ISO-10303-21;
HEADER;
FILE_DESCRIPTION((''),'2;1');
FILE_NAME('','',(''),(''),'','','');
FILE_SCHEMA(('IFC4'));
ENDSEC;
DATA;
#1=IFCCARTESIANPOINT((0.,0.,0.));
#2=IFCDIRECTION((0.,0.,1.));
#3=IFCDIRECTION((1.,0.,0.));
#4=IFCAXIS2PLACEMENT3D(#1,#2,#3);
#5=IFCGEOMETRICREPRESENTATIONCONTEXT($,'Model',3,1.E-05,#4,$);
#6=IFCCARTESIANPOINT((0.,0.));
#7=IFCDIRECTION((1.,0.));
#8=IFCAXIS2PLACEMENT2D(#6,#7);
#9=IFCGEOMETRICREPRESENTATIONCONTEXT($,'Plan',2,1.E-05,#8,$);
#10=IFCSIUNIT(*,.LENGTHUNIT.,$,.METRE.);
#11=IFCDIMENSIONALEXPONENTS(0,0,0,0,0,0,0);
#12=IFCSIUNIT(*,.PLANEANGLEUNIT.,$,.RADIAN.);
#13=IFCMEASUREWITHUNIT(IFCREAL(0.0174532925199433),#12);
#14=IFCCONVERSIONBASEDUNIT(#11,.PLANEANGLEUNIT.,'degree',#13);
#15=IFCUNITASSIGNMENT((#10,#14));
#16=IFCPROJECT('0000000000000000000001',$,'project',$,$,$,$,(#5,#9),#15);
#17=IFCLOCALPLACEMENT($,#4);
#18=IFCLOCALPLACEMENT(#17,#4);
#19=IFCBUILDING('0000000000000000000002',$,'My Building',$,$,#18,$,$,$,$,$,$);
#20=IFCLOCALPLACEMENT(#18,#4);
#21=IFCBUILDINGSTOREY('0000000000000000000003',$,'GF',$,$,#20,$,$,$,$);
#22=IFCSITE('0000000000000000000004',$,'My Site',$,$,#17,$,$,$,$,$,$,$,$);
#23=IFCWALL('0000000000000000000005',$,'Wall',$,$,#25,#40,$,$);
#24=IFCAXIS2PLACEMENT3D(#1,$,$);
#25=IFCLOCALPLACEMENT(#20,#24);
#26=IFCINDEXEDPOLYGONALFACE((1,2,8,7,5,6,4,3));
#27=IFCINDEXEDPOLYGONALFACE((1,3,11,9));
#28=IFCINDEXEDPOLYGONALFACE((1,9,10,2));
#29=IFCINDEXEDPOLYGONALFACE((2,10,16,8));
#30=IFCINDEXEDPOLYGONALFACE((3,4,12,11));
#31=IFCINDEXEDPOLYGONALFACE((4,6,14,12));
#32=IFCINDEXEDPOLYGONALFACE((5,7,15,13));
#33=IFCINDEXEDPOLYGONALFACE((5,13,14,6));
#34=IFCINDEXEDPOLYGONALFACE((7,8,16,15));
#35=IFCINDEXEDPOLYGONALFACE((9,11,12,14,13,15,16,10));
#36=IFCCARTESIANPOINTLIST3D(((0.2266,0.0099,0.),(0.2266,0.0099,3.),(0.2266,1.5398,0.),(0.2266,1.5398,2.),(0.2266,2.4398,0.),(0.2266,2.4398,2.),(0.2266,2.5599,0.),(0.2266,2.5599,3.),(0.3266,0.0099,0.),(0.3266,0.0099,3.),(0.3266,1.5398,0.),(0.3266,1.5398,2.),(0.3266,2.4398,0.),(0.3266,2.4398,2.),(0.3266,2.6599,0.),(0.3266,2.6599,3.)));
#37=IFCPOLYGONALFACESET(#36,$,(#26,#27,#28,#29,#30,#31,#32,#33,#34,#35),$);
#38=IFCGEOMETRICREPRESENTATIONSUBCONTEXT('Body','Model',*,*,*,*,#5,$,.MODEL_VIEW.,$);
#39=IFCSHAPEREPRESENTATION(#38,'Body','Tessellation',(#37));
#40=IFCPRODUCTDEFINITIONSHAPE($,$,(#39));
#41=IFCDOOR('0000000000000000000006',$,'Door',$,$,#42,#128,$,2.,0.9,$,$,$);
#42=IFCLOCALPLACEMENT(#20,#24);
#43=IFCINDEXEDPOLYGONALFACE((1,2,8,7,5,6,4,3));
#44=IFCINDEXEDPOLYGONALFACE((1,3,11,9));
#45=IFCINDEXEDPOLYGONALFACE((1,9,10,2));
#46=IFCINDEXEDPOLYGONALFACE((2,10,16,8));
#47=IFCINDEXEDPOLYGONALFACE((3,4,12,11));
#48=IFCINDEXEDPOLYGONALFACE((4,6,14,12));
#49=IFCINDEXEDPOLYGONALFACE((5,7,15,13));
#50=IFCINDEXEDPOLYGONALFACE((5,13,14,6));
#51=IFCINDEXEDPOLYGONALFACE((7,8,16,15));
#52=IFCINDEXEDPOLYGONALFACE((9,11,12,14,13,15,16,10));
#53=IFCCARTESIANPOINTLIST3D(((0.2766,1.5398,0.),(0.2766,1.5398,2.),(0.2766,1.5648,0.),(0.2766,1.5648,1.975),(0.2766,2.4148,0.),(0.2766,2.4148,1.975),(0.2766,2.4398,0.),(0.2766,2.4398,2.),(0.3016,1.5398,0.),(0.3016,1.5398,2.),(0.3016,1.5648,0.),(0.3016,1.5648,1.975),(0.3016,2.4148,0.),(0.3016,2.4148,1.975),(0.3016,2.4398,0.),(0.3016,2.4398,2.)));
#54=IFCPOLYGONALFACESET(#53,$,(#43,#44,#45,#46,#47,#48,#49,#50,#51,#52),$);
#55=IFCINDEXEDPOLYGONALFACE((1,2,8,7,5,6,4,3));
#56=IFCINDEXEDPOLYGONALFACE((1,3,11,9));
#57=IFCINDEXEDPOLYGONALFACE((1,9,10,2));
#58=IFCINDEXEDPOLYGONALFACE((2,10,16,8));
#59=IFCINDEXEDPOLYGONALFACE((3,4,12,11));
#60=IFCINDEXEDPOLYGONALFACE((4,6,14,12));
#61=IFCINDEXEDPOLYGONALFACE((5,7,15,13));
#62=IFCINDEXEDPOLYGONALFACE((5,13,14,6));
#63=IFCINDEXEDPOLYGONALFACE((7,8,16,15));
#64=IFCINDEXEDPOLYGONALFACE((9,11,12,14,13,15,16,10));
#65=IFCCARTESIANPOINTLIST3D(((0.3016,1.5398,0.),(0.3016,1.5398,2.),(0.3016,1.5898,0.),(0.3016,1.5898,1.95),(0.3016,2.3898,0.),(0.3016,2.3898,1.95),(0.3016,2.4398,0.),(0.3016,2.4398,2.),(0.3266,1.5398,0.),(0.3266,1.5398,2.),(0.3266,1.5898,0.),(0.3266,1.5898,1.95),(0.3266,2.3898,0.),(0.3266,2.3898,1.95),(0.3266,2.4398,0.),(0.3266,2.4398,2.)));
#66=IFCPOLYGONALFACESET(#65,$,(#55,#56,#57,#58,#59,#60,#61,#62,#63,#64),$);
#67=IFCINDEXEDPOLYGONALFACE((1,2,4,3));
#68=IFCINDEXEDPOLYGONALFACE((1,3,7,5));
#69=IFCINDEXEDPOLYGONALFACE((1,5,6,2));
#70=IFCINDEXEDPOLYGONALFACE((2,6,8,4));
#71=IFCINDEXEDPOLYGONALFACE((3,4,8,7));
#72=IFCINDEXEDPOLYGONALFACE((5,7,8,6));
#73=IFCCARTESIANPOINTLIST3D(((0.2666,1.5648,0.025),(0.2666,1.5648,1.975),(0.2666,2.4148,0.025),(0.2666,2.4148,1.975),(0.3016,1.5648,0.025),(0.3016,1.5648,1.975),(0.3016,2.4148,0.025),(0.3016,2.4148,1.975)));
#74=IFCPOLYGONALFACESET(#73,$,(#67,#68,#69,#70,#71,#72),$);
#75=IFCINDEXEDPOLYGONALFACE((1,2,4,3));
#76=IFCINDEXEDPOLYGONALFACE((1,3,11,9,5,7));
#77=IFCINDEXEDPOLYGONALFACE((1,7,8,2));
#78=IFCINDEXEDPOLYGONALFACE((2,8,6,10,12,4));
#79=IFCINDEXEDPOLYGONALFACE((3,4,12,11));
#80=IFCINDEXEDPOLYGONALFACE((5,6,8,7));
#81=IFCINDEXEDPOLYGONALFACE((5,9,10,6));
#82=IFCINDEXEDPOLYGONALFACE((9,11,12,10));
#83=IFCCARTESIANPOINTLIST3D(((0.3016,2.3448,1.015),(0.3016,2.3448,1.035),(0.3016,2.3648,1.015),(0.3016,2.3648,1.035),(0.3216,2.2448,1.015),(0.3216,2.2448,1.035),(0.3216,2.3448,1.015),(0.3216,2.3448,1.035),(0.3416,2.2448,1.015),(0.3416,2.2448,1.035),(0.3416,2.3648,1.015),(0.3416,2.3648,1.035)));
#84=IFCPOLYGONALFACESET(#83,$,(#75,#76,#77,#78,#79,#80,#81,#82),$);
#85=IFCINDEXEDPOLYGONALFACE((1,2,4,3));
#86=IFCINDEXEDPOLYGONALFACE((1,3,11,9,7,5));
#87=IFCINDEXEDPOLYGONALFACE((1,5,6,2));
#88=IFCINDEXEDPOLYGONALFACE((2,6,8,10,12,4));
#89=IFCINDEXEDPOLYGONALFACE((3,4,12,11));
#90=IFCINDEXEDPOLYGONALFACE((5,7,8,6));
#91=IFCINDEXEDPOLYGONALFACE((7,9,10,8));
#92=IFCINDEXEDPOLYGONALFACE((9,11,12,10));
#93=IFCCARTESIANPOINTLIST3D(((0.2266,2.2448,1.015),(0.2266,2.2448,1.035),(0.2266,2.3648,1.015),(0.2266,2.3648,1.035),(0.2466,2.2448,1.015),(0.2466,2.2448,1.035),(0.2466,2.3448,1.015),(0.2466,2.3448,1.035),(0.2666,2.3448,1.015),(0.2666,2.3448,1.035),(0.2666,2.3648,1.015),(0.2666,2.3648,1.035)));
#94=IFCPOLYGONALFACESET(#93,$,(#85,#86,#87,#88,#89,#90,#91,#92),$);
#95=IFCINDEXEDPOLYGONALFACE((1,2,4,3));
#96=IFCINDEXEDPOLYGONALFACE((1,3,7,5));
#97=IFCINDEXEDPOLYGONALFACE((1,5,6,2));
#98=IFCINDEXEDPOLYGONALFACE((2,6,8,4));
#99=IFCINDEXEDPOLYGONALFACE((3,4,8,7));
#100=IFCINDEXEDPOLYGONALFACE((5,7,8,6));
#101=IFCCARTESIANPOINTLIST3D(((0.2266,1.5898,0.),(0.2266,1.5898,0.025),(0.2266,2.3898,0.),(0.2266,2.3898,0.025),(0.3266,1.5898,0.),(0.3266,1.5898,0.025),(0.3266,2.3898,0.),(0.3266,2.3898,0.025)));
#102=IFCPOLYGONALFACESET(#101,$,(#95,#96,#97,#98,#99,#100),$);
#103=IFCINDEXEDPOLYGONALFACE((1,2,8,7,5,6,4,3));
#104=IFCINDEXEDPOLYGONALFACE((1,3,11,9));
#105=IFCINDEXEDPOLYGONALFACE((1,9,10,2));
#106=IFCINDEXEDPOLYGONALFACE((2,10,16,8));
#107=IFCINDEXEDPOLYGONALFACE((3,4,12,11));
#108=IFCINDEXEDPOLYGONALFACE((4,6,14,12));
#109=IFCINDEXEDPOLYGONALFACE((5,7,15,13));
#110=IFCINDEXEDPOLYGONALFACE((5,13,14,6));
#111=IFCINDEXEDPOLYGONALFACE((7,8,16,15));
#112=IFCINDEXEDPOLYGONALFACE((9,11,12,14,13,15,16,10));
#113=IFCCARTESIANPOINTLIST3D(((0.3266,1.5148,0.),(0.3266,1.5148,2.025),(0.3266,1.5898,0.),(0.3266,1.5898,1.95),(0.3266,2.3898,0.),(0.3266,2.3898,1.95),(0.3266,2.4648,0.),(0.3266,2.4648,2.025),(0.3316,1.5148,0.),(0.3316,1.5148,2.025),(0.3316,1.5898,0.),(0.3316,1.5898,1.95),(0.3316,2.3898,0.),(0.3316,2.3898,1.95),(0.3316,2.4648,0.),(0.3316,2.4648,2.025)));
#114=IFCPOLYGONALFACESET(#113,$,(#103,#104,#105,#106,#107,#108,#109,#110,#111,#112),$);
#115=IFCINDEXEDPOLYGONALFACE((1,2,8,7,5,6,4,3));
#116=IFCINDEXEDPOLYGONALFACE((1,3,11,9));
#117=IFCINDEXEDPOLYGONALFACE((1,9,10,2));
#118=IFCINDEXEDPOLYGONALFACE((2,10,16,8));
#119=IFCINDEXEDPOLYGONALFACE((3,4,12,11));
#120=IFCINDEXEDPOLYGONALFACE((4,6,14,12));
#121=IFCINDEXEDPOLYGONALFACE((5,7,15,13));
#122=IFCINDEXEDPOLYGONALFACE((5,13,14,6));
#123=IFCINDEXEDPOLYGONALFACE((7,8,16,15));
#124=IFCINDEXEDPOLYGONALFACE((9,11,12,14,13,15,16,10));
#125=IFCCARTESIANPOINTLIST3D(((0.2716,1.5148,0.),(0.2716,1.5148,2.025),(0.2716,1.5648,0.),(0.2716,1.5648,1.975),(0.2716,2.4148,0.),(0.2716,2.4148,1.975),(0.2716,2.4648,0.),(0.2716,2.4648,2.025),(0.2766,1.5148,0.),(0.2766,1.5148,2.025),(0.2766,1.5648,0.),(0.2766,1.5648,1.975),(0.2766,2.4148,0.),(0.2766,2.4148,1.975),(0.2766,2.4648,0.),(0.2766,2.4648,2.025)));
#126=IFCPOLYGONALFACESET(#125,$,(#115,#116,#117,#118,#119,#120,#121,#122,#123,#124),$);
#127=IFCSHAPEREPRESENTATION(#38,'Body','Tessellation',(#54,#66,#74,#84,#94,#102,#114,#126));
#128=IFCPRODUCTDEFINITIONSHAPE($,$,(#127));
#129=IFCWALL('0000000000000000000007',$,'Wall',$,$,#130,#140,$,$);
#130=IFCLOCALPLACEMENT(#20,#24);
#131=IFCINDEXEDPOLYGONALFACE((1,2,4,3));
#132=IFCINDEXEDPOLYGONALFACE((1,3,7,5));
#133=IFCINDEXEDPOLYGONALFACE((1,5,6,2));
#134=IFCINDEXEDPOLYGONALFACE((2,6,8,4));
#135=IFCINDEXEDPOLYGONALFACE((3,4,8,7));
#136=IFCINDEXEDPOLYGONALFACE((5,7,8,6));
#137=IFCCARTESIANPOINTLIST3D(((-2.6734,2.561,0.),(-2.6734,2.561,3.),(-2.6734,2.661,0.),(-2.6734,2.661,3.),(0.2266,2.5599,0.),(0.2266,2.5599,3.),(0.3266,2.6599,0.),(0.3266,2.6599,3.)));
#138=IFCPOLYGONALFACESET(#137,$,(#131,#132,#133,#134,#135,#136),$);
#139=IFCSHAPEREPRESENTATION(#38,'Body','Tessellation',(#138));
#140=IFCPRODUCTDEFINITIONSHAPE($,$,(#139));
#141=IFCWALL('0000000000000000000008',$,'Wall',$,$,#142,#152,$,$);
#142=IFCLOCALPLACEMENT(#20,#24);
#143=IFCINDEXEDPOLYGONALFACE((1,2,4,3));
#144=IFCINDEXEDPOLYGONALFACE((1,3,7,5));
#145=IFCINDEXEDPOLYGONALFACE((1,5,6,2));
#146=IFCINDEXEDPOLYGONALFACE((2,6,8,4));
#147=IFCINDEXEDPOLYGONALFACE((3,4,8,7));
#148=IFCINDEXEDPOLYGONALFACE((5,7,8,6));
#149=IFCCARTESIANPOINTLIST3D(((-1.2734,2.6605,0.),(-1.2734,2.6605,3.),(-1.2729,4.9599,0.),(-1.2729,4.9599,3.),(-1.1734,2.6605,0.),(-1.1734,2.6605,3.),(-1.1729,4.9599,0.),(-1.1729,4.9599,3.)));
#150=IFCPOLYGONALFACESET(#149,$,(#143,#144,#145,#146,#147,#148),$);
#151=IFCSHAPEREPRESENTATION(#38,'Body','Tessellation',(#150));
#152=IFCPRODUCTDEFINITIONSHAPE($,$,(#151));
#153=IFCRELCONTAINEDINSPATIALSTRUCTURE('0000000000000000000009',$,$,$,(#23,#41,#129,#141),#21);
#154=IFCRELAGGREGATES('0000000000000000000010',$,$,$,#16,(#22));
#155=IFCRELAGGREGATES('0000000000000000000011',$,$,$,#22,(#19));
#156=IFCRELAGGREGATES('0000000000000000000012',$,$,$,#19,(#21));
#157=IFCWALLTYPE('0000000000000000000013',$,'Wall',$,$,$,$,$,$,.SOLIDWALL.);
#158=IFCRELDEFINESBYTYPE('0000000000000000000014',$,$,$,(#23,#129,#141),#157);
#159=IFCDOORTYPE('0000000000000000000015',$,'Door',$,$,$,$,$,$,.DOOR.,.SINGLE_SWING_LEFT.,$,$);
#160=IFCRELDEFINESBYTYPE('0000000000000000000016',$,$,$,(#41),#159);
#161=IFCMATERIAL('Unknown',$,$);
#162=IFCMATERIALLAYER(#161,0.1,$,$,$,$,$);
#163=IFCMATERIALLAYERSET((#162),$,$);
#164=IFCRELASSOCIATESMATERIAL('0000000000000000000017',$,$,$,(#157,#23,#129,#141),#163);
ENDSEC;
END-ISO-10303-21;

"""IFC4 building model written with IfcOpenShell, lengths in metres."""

from ifc_helpers import new_model, entity, si_unit, converted_unit, frame, origin_with_axes, origin_2d_with_axis, place, context, subcontext, project, spatial, line, indexed_curve, outline, extrude, shape, source, transform, mapped, material, layer, layer_set, layer_usage, type_object, type_shapes, element, fill, save


model = new_model("IFC4")

# Units and contexts
model_context = context("Model", 3, precision=1e-05, world=origin_with_axes())
plan_context = context("Plan", 2, precision=1e-05, world=origin_2d_with_axis())
body_context_1 = subcontext(model_context, "Body", "Model", "MODEL_VIEW")
body_context_2 = subcontext(plan_context, "Body", "Plan", "PLAN_VIEW")
ifc_project = project(units=[si_unit("LENGTHUNIT", "METRE"), converted_unit("PLANEANGLEUNIT", "degree", entity("IfcReal", 0.0174532925199433), si_unit("PLANEANGLEUNIT", "RADIAN"), dimensions=[0, 0, 0, 0, 0, 0, 0])], contexts=[model_context, plan_context])

# Site, building, storey
site_placement = place(None, origin_with_axes())
site = spatial("IfcSite", under=ifc_project, at=site_placement, Name="My Site")
building_placement = place(site_placement, origin_with_axes())
building = spatial("IfcBuilding", under=site, at=building_placement, Name="My Building")
storey_placement = place(building_placement, origin_with_axes())
storey = spatial("IfcBuildingStorey", under=building, at=storey_placement, Name="GF")

# Shared definitions
ifc_material_1 = material(Name="Unknown")

# Shared definitions
ifc_layer_1 = layer(ifc_material_1, 0.1)
ifc_layer_set_1 = layer_set([ifc_layer_1])
wall_type = type_object("IfcWallType", Name="Wall", PredefinedType="SOLIDWALL", material=ifc_layer_set_1)

# Shared definitions
shared_shape_1 = source(origin_with_axes(), body_context_1, "Body", "SweptSolid", [
    extrude(outline(indexed_curve([(0.0, 0.0), (0.9, 0.0), (0.9, 2.0), (0.0, 2.0)], segments=[line(1, 2, 3, 4, 1)])), frame((0.0, -0.6, 0.0), z_axis=(0.0, -1.0, 0.0), x_axis=(1.0, 0.0, 0.0)), (0.0, 0.0, -1.0), 1.2),
])
door_type = type_object("IfcDoorType", Name="Door", OperationType="SINGLE_SWING_LEFT", PredefinedType="DOOR")
shared_shape_2 = source(origin_with_axes(), body_context_1, "Body", "SweptSolid", [
    extrude(outline(indexed_curve([(0.0, 0.0), (0.0, 2.0), (0.9, 2.0), (0.9, 0.0), (0.875, 0.0), (0.875, 1.975), (0.025, 1.975), (0.025, 0.0)], segments=[line(1, 2, 3, 4, 5, 6, 7, 8, 1)])), frame((0.0, 0.025, 0.0), z_axis=(0.0, -1.0, 0.0), x_axis=(1.0, 0.0, 0.0)), (0.0, 0.0, -1.0), 0.025),
    extrude(outline(indexed_curve([(0.0, 0.0), (0.0, 2.0), (0.9, 2.0), (0.9, 0.0), (0.85, 0.0), (0.85, 1.95), (0.05, 1.95), (0.05, 0.0)], segments=[line(1, 2, 3, 4, 5, 6, 7, 8, 1)])), frame((0.0, 0.0, 0.0), z_axis=(0.0, -1.0, 0.0), x_axis=(1.0, 0.0, 0.0)), (0.0, 0.0, -1.0), 0.025),
    extrude(outline(indexed_curve([(0.0, 0.0), (0.85, 0.0), (0.85, 0.035), (0.0, 0.035)], segments=[line(1, 2, 3, 4, 1)])), frame((0.025, 0.025, 0.025), z_axis=(0.0, 0.0, 1.0), x_axis=(1.0, 0.0, 0.0)), (0.0, 0.0, 1.0), 1.95),
    extrude(outline(indexed_curve([(0.0, 0.0), (0.0, -0.04), (-0.12, -0.04), (-0.12, -0.02), (-0.02, -0.02), (-0.02, 0.0)], segments=[line(1, 2, 3, 4, 5, 6, 1)])), frame((0.825, 0.025, 1.015), z_axis=(0.0, 0.0, 1.0), x_axis=(1.0, 0.0, 0.0)), (0.0, 0.0, 1.0), 0.02),
    extrude(outline(indexed_curve([(0.0, 0.0), (0.0, 0.04), (-0.12, 0.04), (-0.12, 0.02), (-0.02, 0.02), (-0.02, 0.0)], segments=[line(1, 2, 3, 4, 5, 6, 1)])), frame((0.825, 0.06, 1.015), z_axis=(0.0, 0.0, 1.0), x_axis=(1.0, 0.0, 0.0)), (0.0, 0.0, 1.0), 0.02),
    extrude(outline(indexed_curve([(0.0, 0.0), (0.8, 0.0), (0.8, 0.1), (0.0, 0.1)], segments=[line(1, 2, 3, 4, 1)])), frame((0.05, 0.0, 0.0), z_axis=(0.0, 0.0, 1.0), x_axis=(1.0, 0.0, 0.0)), (0.0, 0.0, 1.0), 0.025),
    extrude(outline(indexed_curve([(0.0, 0.0), (0.0, 2.025), (0.95, 2.025), (0.95, 0.0), (0.875, 0.0), (0.875, 1.95), (0.075, 1.95), (0.075, 0.0)], segments=[line(1, 2, 3, 4, 5, 6, 7, 8, 1)])), frame((-0.025, -0.005, 0.0), z_axis=(0.0, -1.0, 0.0), x_axis=(1.0, 0.0, 0.0)), (0.0, 0.0, -1.0), 0.005),
    extrude(outline(indexed_curve([(0.0, 0.0), (0.0, 2.025), (0.95, 2.025), (0.95, 0.0), (0.9, 0.0), (0.9, 1.975), (0.05, 1.975), (0.05, 0.0)], segments=[line(1, 2, 3, 4, 5, 6, 7, 8, 1)])), frame((-0.025, 0.05, 0.0), z_axis=(0.0, -1.0, 0.0), x_axis=(1.0, 0.0, 0.0)), (0.0, 0.0, -1.0), 0.005),
])
shared_shape_3 = source(origin_with_axes(), body_context_2, "Body", "Curve2D", [
    entity("IfcIndexedPolyCurve", entity("IfcCartesianPointList2D", [[0.0, 0.0], [0.0, 0.05], [0.025, 0.05], [0.025, 0.025], [0.05, 0.025], [0.05, 0.0]]), [entity("IfcLineIndex", [1, 2, 3, 4, 5, 6, 1])]),
    entity("IfcIndexedPolyCurve", entity("IfcCartesianPointList2D", [[0.9, 0.0], [0.9, 0.05], [0.875, 0.05], [0.875, 0.025], [0.85, 0.025], [0.85, 0.0]]), [entity("IfcLineIndex", [1, 2, 3, 4, 5, 6, 1])]),
    entity("IfcTrimmedCurve", entity("IfcEllipse", entity("IfcAxis2Placement2D", entity("IfcCartesianPoint", [0.06, 0.05]), entity("IfcDirection", [1.0, 0.0])), 0.815, 0.85), [entity("IfcCartesianPoint", [0.875, 0.05])], [entity("IfcCartesianPoint", [0.06, 0.9])], True, "CARTESIAN"),
    entity("IfcIndexedPolyCurve", entity("IfcCartesianPointList2D", [[0.025, 0.05], [0.06, 0.05], [0.06, 0.9], [0.025, 0.9]]), [entity("IfcLineIndex", [1, 2, 3, 4, 1])]),
])
type_shapes(door_type, [shared_shape_2, shared_shape_3])

# Wall, opening, door
ifc_layer_usage_1 = layer_usage(ifc_layer_set_1, "AXIS2", "POSITIVE", 0.0)
wall_1_placement = place(storey_placement, frame((0.3266, 0.0099, 0.0), z_axis=(0.0, 0.0, 1.0), x_axis=(0.0, 1.0, 0.0)))
wall_1 = element("IfcWall", 1, at=wall_1_placement, inside=storey, type_object=wall_type, material=ifc_layer_usage_1, Name="Wall", context=body_context_1, shape_type="SweptSolid", body=[
    extrude(outline(indexed_curve([(0.0, 0.0), (0.0, 0.1), (2.55, 0.1), (2.65, 0.0)], segments=[line(1, 2, 3, 4, 1)])), origin_with_axes(), (0.0, 0.0, 1.0), 3.0),
])
opening_1_placement = place(wall_1_placement, frame((1.5299, 0.0, 0.0), z_axis=(0.0, 0.0, 1.0), x_axis=(1.0, 0.0, 0.0)))
opening_1 = element("IfcOpeningElement", 2, at=opening_1_placement, cuts=wall_1, PredefinedType="OPENING", context=body_context_1, shape_type="MappedRepresentation", body=[
    mapped(shared_shape_1, transform((0.0, 0.0, 0.0), x_axis=(1.0, 0.0, 0.0), y_axis=(0.0, 1.0, 0.0), z_axis=(0.0, 0.0, 1.0), scale=1.0)),
])
door_1_placement = place(opening_1_placement, frame((0.0, 0.0, 0.0), z_axis=(0.0, 0.0, 1.0), x_axis=(1.0, 0.0, 0.0)))
door_1 = element("IfcDoor", 3, at=door_1_placement, inside=storey, type_object=door_type, Name="Door", OverallHeight=2.0, OverallWidth=0.9, shapes=[
    shape(body_context_1, "Body", "MappedRepresentation", [mapped(shared_shape_2, transform((0.0, 0.0, 0.0), x_axis=(1.0, 0.0, 0.0), y_axis=(0.0, 1.0, 0.0), z_axis=(0.0, 0.0, 1.0), scale=1.0))]),
    shape(body_context_2, "Body", "MappedRepresentation", [mapped(shared_shape_3, transform((0.0, 0.0, 0.0), x_axis=(1.0, 0.0, 0.0), y_axis=(0.0, 1.0, 0.0), z_axis=(0.0, 0.0, 1.0), scale=1.0))]),
])
fill(opening_1, door_1)

# Walls
ifc_layer_usage_2 = layer_usage(ifc_layer_set_1, "AXIS2", "POSITIVE", 0.0)
wall_2_placement = place(storey_placement, frame((0.3266, 2.6599, 0.0), z_axis=(0.0, 0.0, 1.0), x_axis=(-1.0, 0.000381, 0.0)))
element("IfcWall", 4, at=wall_2_placement, inside=storey, type_object=wall_type, material=ifc_layer_usage_2, Name="Wall", context=body_context_1, shape_type="SweptSolid", body=[
    extrude(outline(indexed_curve([(0.0, 0.0), (0.1, 0.1), (3.0, 0.1), (3.0, 0.0)], segments=[line(1, 2, 3, 4, 1)])), origin_with_axes(), (0.0, 0.0, 1.0), 3.0),
])
ifc_layer_usage_3 = layer_usage(ifc_layer_set_1, "AXIS2", "POSITIVE", 0.0)
wall_3_placement = place(storey_placement, frame((-1.1734, 2.6605, 0.0), z_axis=(0.0, 0.0, 1.0), x_axis=(0.000197, 1.0, 0.0)))
element("IfcWall", 5, at=wall_3_placement, inside=storey, type_object=wall_type, material=ifc_layer_usage_3, Name="Wall", context=body_context_1, shape_type="SweptSolid", body=[
    extrude(outline(indexed_curve([(0.0, 0.0), (0.0, 0.1), (2.2994, 0.1), (2.2994, 0.0)], segments=[line(1, 2, 3, 4, 1)])), origin_with_axes(), (0.0, 0.0, 1.0), 3.0),
])

save(model, "model.ifc")
